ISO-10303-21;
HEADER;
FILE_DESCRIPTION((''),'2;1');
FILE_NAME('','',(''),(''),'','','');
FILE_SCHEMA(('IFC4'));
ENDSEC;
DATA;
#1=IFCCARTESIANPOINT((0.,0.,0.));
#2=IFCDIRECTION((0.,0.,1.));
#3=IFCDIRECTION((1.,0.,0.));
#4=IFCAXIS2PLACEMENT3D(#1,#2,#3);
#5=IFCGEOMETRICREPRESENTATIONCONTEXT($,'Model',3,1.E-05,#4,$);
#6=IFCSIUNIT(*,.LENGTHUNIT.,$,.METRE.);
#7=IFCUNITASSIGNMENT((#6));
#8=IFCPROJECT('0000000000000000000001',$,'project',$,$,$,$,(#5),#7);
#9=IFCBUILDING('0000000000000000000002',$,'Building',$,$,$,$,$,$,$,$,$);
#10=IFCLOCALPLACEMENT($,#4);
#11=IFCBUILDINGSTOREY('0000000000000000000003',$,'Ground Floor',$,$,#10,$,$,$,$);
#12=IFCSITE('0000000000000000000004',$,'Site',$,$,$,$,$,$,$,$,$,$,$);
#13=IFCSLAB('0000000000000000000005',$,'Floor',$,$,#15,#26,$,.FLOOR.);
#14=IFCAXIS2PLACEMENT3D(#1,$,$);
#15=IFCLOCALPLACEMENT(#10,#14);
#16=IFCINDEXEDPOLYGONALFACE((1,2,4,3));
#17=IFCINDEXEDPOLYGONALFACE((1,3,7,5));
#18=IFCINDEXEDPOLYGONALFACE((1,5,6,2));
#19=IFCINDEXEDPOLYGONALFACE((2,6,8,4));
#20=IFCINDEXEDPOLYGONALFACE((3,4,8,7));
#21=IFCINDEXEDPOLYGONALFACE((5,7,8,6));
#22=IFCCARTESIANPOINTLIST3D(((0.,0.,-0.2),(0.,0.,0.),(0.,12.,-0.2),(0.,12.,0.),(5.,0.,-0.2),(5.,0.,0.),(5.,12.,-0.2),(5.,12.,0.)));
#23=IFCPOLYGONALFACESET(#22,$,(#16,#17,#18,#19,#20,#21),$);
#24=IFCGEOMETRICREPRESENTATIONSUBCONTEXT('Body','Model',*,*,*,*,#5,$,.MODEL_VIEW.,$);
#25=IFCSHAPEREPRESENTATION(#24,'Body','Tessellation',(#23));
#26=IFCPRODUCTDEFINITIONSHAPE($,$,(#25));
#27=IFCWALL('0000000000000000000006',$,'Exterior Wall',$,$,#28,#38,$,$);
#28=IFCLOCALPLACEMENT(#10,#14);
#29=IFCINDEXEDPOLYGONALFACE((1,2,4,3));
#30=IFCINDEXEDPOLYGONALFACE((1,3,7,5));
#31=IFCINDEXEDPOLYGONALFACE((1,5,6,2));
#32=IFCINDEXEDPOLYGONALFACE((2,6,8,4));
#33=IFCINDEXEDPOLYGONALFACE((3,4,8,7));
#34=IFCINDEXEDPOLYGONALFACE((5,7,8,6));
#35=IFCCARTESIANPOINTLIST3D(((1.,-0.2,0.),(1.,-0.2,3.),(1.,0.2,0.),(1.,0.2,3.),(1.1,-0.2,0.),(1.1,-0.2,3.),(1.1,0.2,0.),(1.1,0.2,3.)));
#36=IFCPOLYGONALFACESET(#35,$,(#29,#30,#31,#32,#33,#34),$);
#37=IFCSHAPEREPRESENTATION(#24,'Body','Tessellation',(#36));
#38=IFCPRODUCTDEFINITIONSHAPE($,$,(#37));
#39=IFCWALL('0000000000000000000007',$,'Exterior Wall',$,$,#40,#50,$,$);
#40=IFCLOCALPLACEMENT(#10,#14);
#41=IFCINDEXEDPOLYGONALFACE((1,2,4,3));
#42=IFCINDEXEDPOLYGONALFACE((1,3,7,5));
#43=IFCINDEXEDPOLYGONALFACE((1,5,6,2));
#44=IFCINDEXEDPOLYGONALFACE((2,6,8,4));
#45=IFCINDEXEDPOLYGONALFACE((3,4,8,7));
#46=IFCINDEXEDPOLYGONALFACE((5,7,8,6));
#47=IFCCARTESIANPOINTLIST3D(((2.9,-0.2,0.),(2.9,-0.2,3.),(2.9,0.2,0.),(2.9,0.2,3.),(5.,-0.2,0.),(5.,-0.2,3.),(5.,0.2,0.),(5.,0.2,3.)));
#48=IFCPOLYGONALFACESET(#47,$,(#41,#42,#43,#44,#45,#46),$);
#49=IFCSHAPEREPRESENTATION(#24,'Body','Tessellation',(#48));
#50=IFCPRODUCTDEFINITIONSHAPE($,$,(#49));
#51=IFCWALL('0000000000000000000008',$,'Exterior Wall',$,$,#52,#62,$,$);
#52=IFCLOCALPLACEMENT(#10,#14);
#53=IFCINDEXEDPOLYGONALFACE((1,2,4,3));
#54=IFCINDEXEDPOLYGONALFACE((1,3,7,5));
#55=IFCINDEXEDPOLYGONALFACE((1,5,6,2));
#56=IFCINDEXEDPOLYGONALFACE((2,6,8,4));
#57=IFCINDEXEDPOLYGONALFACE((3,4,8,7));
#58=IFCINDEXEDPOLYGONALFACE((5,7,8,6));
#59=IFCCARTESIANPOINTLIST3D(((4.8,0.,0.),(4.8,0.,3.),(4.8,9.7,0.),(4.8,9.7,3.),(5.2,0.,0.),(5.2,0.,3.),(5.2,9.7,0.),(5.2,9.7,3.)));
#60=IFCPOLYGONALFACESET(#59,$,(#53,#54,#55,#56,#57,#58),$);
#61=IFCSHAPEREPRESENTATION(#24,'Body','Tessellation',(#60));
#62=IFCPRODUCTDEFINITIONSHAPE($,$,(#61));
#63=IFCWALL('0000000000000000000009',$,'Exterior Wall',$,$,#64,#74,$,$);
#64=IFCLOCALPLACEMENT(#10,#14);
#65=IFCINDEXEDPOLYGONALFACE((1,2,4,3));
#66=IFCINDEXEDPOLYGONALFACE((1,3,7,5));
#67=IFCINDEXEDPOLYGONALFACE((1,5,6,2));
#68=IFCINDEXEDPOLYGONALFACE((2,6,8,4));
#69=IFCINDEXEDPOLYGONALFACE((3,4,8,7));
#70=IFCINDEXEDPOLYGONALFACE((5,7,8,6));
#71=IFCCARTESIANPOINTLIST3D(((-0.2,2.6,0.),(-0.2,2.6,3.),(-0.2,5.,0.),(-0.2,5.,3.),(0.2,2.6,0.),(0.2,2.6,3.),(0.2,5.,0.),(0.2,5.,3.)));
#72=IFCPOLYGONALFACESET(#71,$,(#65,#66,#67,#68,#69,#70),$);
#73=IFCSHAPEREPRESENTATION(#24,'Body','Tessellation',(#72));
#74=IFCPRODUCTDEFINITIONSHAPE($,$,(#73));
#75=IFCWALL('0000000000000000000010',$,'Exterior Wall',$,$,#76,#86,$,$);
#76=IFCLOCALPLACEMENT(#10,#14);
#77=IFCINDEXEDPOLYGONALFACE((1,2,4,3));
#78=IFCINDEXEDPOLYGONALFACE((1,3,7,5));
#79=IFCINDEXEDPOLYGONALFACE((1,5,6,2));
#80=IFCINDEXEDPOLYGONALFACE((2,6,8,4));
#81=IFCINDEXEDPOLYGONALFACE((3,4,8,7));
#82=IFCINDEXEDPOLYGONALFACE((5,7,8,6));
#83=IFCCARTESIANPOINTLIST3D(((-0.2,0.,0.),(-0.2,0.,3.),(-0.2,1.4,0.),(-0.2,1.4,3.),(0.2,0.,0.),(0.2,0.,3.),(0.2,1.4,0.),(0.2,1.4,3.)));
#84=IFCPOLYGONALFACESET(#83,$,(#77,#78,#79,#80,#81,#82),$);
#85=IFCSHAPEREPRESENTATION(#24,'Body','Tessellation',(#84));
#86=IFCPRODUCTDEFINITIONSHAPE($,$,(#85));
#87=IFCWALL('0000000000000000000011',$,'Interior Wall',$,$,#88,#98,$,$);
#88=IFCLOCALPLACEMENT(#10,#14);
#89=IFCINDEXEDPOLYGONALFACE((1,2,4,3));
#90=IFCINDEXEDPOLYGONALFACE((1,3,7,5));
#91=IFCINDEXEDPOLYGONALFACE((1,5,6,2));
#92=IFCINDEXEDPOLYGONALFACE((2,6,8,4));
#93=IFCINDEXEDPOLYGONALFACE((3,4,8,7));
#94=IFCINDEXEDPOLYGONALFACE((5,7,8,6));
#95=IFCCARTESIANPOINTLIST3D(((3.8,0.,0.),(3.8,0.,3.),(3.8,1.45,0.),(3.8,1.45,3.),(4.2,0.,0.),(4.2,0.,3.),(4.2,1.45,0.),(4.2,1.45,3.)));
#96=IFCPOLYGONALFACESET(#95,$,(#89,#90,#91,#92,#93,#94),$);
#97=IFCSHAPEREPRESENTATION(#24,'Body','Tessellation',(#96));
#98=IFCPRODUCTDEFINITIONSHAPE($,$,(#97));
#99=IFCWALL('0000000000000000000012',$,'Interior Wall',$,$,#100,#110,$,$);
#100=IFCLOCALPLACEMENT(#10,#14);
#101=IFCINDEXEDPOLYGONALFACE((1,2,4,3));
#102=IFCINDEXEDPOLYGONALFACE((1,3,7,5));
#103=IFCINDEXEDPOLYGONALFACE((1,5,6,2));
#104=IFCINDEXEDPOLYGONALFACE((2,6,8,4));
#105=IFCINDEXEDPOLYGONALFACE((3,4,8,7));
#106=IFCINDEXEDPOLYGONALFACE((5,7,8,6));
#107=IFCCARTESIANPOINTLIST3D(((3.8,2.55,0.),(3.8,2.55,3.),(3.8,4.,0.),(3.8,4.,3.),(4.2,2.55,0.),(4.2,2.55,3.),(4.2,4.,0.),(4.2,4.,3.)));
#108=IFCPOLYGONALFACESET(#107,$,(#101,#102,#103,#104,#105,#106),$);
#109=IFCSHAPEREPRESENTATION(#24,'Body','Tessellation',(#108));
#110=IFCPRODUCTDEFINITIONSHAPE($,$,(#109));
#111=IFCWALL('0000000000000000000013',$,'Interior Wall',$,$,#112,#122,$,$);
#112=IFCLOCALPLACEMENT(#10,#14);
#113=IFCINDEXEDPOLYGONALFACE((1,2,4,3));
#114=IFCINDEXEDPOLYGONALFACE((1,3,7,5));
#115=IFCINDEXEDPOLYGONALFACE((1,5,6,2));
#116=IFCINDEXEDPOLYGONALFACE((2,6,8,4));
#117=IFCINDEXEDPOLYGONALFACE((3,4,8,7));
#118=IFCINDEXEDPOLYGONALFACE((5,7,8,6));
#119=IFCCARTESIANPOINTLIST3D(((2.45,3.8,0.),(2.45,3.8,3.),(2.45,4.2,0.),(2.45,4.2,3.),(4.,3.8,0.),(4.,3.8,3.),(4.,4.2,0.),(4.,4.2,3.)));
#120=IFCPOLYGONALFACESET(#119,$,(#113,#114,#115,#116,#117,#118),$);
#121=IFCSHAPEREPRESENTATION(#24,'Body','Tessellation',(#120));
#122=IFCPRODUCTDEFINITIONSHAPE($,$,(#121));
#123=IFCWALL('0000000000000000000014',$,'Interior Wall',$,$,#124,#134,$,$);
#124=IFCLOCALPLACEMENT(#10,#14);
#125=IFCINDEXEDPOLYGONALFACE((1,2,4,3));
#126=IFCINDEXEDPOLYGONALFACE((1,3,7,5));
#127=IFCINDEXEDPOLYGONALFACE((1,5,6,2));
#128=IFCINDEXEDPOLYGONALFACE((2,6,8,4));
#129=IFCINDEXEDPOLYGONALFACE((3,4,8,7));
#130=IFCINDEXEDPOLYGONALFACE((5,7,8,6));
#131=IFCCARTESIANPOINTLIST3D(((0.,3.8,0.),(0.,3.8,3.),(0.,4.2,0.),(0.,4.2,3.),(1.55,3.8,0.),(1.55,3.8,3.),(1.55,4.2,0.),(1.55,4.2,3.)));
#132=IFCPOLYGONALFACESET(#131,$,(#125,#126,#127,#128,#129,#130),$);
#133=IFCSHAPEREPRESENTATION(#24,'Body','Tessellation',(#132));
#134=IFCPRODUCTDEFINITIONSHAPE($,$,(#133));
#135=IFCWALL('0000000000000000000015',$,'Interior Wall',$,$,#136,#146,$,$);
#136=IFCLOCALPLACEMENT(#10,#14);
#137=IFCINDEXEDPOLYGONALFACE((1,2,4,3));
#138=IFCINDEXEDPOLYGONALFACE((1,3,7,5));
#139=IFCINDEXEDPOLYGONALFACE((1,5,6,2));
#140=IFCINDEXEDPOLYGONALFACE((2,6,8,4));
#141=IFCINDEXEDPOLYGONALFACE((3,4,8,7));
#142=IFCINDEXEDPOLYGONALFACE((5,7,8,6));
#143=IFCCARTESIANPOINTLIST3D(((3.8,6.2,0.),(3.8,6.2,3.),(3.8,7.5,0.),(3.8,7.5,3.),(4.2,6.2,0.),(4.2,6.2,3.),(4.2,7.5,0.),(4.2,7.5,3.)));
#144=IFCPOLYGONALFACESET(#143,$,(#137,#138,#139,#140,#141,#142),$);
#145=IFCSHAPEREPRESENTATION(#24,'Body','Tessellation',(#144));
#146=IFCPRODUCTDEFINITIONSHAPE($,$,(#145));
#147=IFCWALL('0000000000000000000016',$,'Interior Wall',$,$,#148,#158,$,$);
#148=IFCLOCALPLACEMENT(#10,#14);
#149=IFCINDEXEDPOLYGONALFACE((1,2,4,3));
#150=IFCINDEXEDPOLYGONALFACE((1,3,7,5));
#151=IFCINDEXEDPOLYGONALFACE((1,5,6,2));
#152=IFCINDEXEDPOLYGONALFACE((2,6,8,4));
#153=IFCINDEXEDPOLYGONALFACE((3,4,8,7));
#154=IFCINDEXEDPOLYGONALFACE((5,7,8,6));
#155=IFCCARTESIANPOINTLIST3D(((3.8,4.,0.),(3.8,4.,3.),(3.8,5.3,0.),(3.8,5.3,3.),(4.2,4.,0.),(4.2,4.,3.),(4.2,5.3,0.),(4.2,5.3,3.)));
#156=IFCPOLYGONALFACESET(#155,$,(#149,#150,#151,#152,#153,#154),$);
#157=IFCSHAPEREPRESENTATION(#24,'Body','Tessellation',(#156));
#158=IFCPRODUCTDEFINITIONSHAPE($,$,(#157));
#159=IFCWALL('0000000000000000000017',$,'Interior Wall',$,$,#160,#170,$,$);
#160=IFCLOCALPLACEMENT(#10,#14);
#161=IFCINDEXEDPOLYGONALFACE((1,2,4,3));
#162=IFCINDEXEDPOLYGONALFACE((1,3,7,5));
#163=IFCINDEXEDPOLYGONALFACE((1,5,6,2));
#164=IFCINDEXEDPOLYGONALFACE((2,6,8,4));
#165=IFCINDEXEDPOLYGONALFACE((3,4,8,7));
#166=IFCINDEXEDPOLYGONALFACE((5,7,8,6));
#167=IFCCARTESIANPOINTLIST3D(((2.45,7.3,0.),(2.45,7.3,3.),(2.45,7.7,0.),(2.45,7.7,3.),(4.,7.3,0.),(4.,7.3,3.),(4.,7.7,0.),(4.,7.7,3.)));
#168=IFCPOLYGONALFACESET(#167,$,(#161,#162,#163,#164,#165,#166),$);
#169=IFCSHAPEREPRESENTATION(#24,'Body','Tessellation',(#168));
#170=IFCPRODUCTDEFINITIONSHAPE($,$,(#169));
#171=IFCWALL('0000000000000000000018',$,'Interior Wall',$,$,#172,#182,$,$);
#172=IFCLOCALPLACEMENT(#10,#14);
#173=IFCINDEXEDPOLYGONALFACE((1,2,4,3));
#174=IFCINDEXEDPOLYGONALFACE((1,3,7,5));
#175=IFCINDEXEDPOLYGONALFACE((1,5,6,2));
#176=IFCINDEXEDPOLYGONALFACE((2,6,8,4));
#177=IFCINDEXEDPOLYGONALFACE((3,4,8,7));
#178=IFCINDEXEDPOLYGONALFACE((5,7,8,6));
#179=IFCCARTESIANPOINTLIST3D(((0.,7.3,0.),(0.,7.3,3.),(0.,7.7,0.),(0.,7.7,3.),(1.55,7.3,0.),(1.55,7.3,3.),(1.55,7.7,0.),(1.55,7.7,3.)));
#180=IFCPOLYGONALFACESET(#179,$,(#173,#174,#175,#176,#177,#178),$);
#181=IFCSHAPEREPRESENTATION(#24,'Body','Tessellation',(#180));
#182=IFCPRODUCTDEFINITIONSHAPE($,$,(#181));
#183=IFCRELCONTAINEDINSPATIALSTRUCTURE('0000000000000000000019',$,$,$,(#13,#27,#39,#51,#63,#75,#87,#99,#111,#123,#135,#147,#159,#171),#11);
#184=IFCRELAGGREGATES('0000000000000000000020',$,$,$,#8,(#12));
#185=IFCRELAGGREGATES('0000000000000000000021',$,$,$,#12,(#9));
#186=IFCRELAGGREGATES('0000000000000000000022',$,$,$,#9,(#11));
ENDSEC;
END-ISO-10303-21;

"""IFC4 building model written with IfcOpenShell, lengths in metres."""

from ifc_helpers import new_model, si_unit, frame, origin_with_axes, place, context, subcontext, project, spatial, indexed_curve, outline, extrude, element, save


model = new_model("IFC4")

# Units and contexts
model_context = context("Model", 3, precision=1e-05, world=origin_with_axes())
body_context = subcontext(model_context, "Body", "Model", "MODEL_VIEW")
ifc_project = project(units=[si_unit("LENGTHUNIT", "METRE")], contexts=[model_context])

# Site, building, storey
site = spatial("IfcSite", under=ifc_project, Name="Site")
building = spatial("IfcBuilding", under=site, Name="Building")
storey_placement = place(None, origin_with_axes())
storey = spatial("IfcBuildingStorey", under=building, at=storey_placement, Name="Ground Floor")

# Slab
slab_placement = place(storey_placement, frame((0.0, 0.0, -0.2), z_axis=(0.0, 0.0, 1.0), x_axis=(1.0, 0.0, 0.0)))
element("IfcSlab", 1, at=slab_placement, inside=storey, Name="Floor", PredefinedType="FLOOR", context=body_context, shape_type="SweptSolid", body=[
    extrude(outline(indexed_curve([(0.0, 0.0), (5.0, 0.0), (5.0, 12.0), (0.0, 12.0)])), None, (0.0, 0.0, 1.0), 0.2),
])

# Walls
wall_1_placement = place(storey_placement, frame((1.0, 0.0, 0.0), z_axis=(0.0, 0.0, 1.0), x_axis=(1.0, 0.0, 0.0)))
element("IfcWall", 2, at=wall_1_placement, inside=storey, Name="Exterior Wall", context=body_context, shape_type="SweptSolid", body=[
    extrude(outline(indexed_curve([(0.0, 0.0), (0.0, 0.4), (0.1, 0.4), (0.1, 0.0), (0.0, 0.0)], self_intersect=False)), frame((0.0, -0.2, 0.0), z_axis=(0.0, 0.0, 1.0), x_axis=(1.0, 0.0, 0.0)), (0.0, 0.0, 1.0), 3.0),
])
wall_2_placement = place(storey_placement, frame((2.9, 0.0, 0.0), z_axis=(0.0, 0.0, 1.0), x_axis=(1.0, 0.0, 0.0)))
element("IfcWall", 3, at=wall_2_placement, inside=storey, Name="Exterior Wall", context=body_context, shape_type="SweptSolid", body=[
    extrude(outline(indexed_curve([(0.0, 0.0), (0.0, 0.4), (2.1, 0.4), (2.1, 0.0), (0.0, 0.0)], self_intersect=False)), frame((0.0, -0.2, 0.0), z_axis=(0.0, 0.0, 1.0), x_axis=(1.0, 0.0, 0.0)), (0.0, 0.0, 1.0), 3.0),
])
wall_3_placement = place(storey_placement, frame((5.0, 0.0, 0.0), z_axis=(0.0, 0.0, 1.0), x_axis=(0.0, 1.0, 0.0)))
element("IfcWall", 4, at=wall_3_placement, inside=storey, Name="Exterior Wall", context=body_context, shape_type="SweptSolid", body=[
    extrude(outline(indexed_curve([(0.0, 0.0), (0.0, 0.4), (9.7, 0.4), (9.7, 0.0), (0.0, 0.0)], self_intersect=False)), frame((0.0, -0.2, 0.0), z_axis=(0.0, 0.0, 1.0), x_axis=(1.0, 0.0, 0.0)), (0.0, 0.0, 1.0), 3.0),
])
wall_4_placement = place(storey_placement, frame((0.0, 5.0, 0.0), z_axis=(0.0, 0.0, 1.0), x_axis=(0.0, -1.0, 0.0)))
element("IfcWall", 5, at=wall_4_placement, inside=storey, Name="Exterior Wall", context=body_context, shape_type="SweptSolid", body=[
    extrude(outline(indexed_curve([(0.0, 0.0), (0.0, 0.4), (2.4, 0.4), (2.4, 0.0), (0.0, 0.0)], self_intersect=False)), frame((0.0, -0.2, 0.0), z_axis=(0.0, 0.0, 1.0), x_axis=(1.0, 0.0, 0.0)), (0.0, 0.0, 1.0), 3.0),
])
wall_5_placement = place(storey_placement, frame((0.0, 1.4, 0.0), z_axis=(0.0, 0.0, 1.0), x_axis=(0.0, -1.0, 0.0)))
element("IfcWall", 6, at=wall_5_placement, inside=storey, Name="Exterior Wall", context=body_context, shape_type="SweptSolid", body=[
    extrude(outline(indexed_curve([(0.0, 0.0), (0.0, 0.4), (1.4, 0.4), (1.4, 0.0), (0.0, 0.0)], self_intersect=False)), frame((0.0, -0.2, 0.0), z_axis=(0.0, 0.0, 1.0), x_axis=(1.0, 0.0, 0.0)), (0.0, 0.0, 1.0), 3.0),
])
wall_6_placement = place(storey_placement, frame((4.0, 0.0, 0.0), z_axis=(0.0, 0.0, 1.0), x_axis=(0.0, 1.0, 0.0)))
element("IfcWall", 7, at=wall_6_placement, inside=storey, Name="Interior Wall", context=body_context, shape_type="SweptSolid", body=[
    extrude(outline(indexed_curve([(0.0, 0.0), (0.0, 0.4), (1.45, 0.4), (1.45, 0.0), (0.0, 0.0)], self_intersect=False)), frame((0.0, -0.2, 0.0), z_axis=(0.0, 0.0, 1.0), x_axis=(1.0, 0.0, 0.0)), (0.0, 0.0, 1.0), 3.0),
])
wall_7_placement = place(storey_placement, frame((4.0, 2.55, 0.0), z_axis=(0.0, 0.0, 1.0), x_axis=(0.0, 1.0, 0.0)))
element("IfcWall", 8, at=wall_7_placement, inside=storey, Name="Interior Wall", context=body_context, shape_type="SweptSolid", body=[
    extrude(outline(indexed_curve([(0.0, 0.0), (0.0, 0.4), (1.45, 0.4), (1.45, 0.0), (0.0, 0.0)], self_intersect=False)), frame((0.0, -0.2, 0.0), z_axis=(0.0, 0.0, 1.0), x_axis=(1.0, 0.0, 0.0)), (0.0, 0.0, 1.0), 3.0),
])
for number, where, z_axis, x_axis, name in (
    (9, (4.0, 4.0, 0.0), (0.0, 0.0, 1.0), (-1.0, 0.0, 0.0), "Interior Wall"),
    (10, (1.55, 4.0, 0.0), (0.0, 0.0, 1.0), (-1.0, 0.0, 0.0), "Interior Wall"),
):
    element("IfcWall", number, at=place(storey_placement, frame(where, z_axis=z_axis, x_axis=x_axis)), inside=storey, Name=name, context=body_context, shape_type="SweptSolid", body=[
        extrude(outline(indexed_curve([(0.0, 0.0), (0.0, 0.4), (1.55, 0.4), (1.55, 0.0), (0.0, 0.0)], self_intersect=False)), frame((0.0, -0.2, 0.0), z_axis=(0.0, 0.0, 1.0), x_axis=(1.0, 0.0, 0.0)), (0.0, 0.0, 1.0), 3.0),
    ])
for number, where, z_axis, x_axis, name in (
    (11, (4.0, 7.5, 0.0), (0.0, 0.0, 1.0), (0.0, -1.0, 0.0), "Interior Wall"),
    (12, (4.0, 5.3, 0.0), (0.0, 0.0, 1.0), (0.0, -1.0, 0.0), "Interior Wall"),
):
    element("IfcWall", number, at=place(storey_placement, frame(where, z_axis=z_axis, x_axis=x_axis)), inside=storey, Name=name, context=body_context, shape_type="SweptSolid", body=[
        extrude(outline(indexed_curve([(0.0, 0.0), (0.0, 0.4), (1.3, 0.4), (1.3, 0.0), (0.0, 0.0)], self_intersect=False)), frame((0.0, -0.2, 0.0), z_axis=(0.0, 0.0, 1.0), x_axis=(1.0, 0.0, 0.0)), (0.0, 0.0, 1.0), 3.0),
    ])
for number, where, z_axis, x_axis, name in (
    (13, (4.0, 7.5, 0.0), (0.0, 0.0, 1.0), (-1.0, 0.0, 0.0), "Interior Wall"),
    (14, (1.55, 7.5, 0.0), (0.0, 0.0, 1.0), (-1.0, 0.0, 0.0), "Interior Wall"),
):
    element("IfcWall", number, at=place(storey_placement, frame(where, z_axis=z_axis, x_axis=x_axis)), inside=storey, Name=name, context=body_context, shape_type="SweptSolid", body=[
        extrude(outline(indexed_curve([(0.0, 0.0), (0.0, 0.4), (1.55, 0.4), (1.55, 0.0), (0.0, 0.0)], self_intersect=False)), frame((0.0, -0.2, 0.0), z_axis=(0.0, 0.0, 1.0), x_axis=(1.0, 0.0, 0.0)), (0.0, 0.0, 1.0), 3.0),
    ])

save(model, "model.ifc")
